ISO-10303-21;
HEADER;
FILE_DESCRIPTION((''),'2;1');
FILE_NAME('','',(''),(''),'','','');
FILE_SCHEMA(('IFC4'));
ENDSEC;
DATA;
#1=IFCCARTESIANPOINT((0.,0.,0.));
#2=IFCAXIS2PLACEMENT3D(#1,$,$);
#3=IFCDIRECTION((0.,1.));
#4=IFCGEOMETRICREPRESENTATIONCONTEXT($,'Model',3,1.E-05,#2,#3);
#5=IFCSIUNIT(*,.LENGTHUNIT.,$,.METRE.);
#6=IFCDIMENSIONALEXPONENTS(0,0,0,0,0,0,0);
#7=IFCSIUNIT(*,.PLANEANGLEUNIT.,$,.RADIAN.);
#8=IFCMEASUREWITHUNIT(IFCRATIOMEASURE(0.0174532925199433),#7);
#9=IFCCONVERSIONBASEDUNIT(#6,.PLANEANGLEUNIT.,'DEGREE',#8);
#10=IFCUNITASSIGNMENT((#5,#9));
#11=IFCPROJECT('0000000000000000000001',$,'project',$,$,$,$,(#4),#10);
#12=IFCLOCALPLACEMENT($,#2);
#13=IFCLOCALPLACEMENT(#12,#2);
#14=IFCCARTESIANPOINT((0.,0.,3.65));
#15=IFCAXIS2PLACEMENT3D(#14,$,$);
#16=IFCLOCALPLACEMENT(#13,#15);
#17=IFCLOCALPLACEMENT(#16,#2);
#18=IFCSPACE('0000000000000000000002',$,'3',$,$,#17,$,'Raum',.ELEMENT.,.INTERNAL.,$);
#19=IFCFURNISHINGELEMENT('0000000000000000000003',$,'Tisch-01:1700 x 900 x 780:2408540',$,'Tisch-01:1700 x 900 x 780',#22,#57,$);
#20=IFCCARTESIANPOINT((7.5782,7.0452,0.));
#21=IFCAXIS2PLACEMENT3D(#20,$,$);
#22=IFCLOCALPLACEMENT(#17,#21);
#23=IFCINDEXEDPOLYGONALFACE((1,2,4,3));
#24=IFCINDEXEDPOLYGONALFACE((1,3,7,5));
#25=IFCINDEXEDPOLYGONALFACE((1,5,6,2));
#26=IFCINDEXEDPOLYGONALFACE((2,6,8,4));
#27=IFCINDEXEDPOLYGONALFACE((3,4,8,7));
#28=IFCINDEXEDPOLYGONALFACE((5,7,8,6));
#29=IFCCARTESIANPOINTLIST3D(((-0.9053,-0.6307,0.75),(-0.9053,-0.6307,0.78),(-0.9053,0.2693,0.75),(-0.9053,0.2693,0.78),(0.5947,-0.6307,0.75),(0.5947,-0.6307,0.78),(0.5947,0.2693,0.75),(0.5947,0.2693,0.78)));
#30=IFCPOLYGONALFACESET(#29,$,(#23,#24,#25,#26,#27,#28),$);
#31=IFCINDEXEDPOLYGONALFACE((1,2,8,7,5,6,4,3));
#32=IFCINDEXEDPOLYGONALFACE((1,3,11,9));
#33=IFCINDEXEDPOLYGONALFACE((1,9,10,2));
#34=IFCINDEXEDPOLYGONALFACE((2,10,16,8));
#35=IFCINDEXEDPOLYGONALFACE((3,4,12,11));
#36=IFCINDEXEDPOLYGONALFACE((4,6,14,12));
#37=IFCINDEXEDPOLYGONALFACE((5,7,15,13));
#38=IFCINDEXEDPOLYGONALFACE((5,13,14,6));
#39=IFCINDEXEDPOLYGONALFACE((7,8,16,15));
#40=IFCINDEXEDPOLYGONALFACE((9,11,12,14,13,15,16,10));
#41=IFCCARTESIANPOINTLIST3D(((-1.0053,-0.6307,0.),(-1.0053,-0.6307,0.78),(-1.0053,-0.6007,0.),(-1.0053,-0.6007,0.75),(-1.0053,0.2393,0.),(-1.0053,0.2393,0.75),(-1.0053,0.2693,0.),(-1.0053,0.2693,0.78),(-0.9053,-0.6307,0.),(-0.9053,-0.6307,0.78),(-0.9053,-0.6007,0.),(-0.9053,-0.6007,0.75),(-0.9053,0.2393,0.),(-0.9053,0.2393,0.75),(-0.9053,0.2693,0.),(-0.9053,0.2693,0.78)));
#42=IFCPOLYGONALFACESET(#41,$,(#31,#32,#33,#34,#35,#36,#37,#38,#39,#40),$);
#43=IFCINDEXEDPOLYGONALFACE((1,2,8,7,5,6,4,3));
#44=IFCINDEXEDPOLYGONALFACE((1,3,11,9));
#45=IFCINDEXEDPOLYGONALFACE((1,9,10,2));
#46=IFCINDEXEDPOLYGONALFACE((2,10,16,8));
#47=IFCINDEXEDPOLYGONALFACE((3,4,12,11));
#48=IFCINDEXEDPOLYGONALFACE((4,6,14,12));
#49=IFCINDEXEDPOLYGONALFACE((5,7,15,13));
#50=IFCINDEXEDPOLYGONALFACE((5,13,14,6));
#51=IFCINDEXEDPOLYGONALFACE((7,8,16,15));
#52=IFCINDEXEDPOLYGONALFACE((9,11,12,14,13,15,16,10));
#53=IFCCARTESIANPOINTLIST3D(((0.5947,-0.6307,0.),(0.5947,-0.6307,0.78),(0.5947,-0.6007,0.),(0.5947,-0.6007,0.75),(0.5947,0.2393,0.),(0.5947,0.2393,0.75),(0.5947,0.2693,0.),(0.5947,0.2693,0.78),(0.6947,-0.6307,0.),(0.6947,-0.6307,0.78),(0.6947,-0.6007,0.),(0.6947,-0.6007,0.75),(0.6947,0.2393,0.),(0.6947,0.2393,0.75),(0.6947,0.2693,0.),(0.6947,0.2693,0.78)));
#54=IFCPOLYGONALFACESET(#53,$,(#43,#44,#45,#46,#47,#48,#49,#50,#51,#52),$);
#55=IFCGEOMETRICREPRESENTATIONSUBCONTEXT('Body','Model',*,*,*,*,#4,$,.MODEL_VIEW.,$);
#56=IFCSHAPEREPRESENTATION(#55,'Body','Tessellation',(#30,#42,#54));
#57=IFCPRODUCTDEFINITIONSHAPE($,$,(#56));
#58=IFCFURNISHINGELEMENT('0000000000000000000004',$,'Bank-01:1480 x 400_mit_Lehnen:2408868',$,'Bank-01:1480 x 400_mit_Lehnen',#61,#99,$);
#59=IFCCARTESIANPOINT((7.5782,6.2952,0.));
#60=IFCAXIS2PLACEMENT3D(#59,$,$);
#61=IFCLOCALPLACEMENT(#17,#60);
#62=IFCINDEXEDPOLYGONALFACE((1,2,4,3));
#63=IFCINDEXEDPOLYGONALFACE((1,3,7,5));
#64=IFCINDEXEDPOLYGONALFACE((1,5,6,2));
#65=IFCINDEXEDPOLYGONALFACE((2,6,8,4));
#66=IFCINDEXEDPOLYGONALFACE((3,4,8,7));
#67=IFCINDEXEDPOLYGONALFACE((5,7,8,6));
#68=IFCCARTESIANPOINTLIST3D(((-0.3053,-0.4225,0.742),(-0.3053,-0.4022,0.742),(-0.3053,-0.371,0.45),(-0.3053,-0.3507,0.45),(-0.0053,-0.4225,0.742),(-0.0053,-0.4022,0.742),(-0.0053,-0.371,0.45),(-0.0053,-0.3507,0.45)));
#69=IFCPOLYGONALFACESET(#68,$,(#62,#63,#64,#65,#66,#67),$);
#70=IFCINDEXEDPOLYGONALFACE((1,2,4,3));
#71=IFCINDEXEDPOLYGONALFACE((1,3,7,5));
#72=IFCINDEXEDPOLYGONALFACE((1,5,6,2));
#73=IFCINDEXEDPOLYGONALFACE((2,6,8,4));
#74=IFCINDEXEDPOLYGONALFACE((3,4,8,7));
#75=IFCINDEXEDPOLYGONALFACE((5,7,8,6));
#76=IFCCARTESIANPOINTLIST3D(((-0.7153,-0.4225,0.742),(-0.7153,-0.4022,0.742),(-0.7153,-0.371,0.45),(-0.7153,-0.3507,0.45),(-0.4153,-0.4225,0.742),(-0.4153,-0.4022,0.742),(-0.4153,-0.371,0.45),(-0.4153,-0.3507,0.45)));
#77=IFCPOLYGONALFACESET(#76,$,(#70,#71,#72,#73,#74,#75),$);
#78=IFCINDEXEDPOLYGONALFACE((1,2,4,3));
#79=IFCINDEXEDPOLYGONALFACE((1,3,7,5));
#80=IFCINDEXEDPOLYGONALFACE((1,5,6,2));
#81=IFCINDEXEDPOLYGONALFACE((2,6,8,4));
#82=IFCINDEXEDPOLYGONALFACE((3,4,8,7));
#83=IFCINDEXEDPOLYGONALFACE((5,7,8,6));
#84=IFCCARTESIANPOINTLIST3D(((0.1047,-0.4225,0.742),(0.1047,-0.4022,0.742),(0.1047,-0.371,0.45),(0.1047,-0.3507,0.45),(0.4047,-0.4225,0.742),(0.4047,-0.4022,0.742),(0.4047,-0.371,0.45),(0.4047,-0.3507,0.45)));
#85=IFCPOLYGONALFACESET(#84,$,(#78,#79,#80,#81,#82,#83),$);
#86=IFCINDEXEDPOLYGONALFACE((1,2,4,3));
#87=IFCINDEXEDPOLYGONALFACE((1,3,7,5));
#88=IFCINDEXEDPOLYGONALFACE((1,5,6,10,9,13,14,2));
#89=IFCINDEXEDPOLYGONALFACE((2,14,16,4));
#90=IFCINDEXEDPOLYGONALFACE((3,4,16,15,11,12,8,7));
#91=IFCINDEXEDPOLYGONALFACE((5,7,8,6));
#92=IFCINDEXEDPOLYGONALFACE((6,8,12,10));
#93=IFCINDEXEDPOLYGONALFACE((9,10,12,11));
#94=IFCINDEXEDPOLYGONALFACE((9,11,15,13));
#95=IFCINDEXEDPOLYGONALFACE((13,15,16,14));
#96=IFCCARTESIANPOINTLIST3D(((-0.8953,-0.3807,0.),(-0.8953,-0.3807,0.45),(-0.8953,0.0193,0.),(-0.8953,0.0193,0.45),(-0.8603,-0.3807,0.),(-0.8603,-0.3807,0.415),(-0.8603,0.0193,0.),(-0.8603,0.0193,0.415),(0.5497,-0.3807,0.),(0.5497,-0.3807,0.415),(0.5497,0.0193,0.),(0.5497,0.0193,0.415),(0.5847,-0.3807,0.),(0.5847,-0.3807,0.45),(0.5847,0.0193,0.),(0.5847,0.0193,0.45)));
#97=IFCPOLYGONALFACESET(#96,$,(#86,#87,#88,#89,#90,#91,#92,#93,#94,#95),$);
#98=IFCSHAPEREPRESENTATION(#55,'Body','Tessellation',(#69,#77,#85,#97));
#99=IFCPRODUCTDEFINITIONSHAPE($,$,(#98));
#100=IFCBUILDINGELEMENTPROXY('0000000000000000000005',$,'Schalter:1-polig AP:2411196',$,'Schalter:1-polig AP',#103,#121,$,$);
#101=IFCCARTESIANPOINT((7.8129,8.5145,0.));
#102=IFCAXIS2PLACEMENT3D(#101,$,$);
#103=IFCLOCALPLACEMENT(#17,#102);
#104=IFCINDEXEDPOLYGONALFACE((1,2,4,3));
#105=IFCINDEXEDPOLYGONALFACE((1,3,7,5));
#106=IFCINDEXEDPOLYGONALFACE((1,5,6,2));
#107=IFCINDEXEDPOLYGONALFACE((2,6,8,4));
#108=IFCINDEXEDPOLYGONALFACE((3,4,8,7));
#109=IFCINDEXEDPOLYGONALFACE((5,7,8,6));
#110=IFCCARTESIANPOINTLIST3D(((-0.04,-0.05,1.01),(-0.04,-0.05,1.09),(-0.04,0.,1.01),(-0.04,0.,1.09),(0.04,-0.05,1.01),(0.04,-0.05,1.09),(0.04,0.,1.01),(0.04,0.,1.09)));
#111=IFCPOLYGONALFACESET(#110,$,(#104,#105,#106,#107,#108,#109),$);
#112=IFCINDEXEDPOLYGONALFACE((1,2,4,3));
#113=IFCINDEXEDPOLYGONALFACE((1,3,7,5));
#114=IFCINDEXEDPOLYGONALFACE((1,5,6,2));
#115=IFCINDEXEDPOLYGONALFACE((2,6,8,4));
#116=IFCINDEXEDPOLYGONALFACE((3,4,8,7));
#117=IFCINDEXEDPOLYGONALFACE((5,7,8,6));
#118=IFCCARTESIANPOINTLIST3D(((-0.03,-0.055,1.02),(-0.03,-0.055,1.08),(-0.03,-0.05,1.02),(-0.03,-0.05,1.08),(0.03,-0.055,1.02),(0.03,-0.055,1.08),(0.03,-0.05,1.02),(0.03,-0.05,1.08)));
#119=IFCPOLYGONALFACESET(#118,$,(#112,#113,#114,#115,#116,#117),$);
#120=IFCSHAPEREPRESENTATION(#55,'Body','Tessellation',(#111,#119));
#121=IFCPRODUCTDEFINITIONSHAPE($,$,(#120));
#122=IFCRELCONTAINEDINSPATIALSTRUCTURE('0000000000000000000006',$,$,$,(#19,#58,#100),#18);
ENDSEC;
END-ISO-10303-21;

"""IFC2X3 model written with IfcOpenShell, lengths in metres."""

from ifc_helpers import new_model, entity, si_unit, converted_unit, direction, frame, frame_2d, origin, origin_2d_with_axis, place, context, subcontext, project, spatial, polyline, rectangle, outline, extrude, source, transform, mapped, element, save


model = new_model("IFC2X3")

# Units and contexts
model_context = context("Model", 3, precision=1e-05, world=origin(), true_north=direction((0.0, 1.0)))
body_context = subcontext(model_context, "Body", "Model", "MODEL_VIEW")
ifc_project = project(units=[si_unit("LENGTHUNIT", "METRE"), converted_unit("PLANEANGLEUNIT", "DEGREE", entity("IfcRatioMeasure", 0.0174532925199433), si_unit("PLANEANGLEUNIT", "RADIAN"), dimensions=[0, 0, 0, 0, 0, 0, 0])], contexts=[model_context])

# Shared definitions
placement_1 = place(None, origin())
placement_2 = place(placement_1, origin())

# Shared definitions
placement_3 = place(placement_2, frame((0.0, 0.0, 3.65)))

# Shared definitions
space_placement = place(placement_3, origin())
space = spatial("IfcSpace", at=space_placement, Name="3", LongName="Raum", CompositionType="ELEMENT", InteriorOrExteriorSpace="INTERNAL")

# Furnishing elements
shared_shape_1 = source(origin(), body_context, "Body", "SweptSolid", [
    extrude(rectangle(XDim=1.5, YDim=0.9, at=origin_2d_with_axis()), frame((-0.1553, -0.1807, 0.75), z_axis=(0.0, 0.0, 1.0), x_axis=(-1.0, 0.0, 0.0)), (0.0, 0.0, 1.0), 0.03),
    extrude(outline(polyline([(-0.3975, -0.45), (0.3825, -0.45), (0.3825, -0.42), (-0.3675, -0.42), (-0.3675, 0.42), (0.3825, 0.42), (0.3825, 0.45), (-0.3975, 0.45), (-0.3975, -0.45)])), frame((-1.0053, -0.1807, 0.3825), z_axis=(1.0, 0.0, 0.0), x_axis=(0.0, 0.0, -1.0)), (0.0, 0.0, 1.0), 0.1),
    extrude(outline(polyline([(-0.3975, -0.45), (0.3825, -0.45), (0.3825, -0.42), (-0.3675, -0.42), (-0.3675, 0.42), (0.3825, 0.42), (0.3825, 0.45), (-0.3975, 0.45), (-0.3975, -0.45)])), frame((0.5947, -0.1807, 0.3825), z_axis=(1.0, 0.0, 0.0), x_axis=(0.0, 0.0, -1.0)), (0.0, 0.0, 1.0), 0.1),
])
furnishing_1_placement = place(space_placement, frame((7.5782, 7.0452, 0.0)))
element("IfcFurnishingElement", 1, at=furnishing_1_placement, inside=space, Name="Tisch-01:1700 x 900 x 780:2408540", ObjectType="Tisch-01:1700 x 900 x 780", context=body_context, shape_type="MappedRepresentation", body=[
    mapped(shared_shape_1, transform((0.0, 0.0, 0.0), scale=1.0)),
])
shared_shape_2 = source(origin(), body_context, "Body", "SweptSolid", [
    extrude(outline(polyline([(0.0156, -0.146), (0.0359, -0.146), (-0.0156, 0.146), (-0.0359, 0.146), (0.0156, -0.146)])), frame((-0.3053, -0.3866, 0.596), z_axis=(1.0, 0.0, 0.0), x_axis=(0.0, -1.0, 0.0)), (0.0, 0.0, 1.0), 0.3),
    extrude(outline(polyline([(0.0156, -0.146), (0.0359, -0.146), (-0.0156, 0.146), (-0.0359, 0.146), (0.0156, -0.146)])), frame((-0.7153, -0.3866, 0.596), z_axis=(1.0, 0.0, 0.0), x_axis=(0.0, -1.0, 0.0)), (0.0, 0.0, 1.0), 0.3),
    extrude(outline(polyline([(0.0156, -0.146), (0.0359, -0.146), (-0.0156, 0.146), (-0.0359, 0.146), (0.0156, -0.146)])), frame((0.1047, -0.3866, 0.596), z_axis=(1.0, 0.0, 0.0), x_axis=(0.0, -1.0, 0.0)), (0.0, 0.0, 1.0), 0.3),
    extrude(outline(polyline([(-0.74, -0.2337), (0.74, -0.2337), (0.74, 0.2163), (0.705, 0.2163), (0.705, -0.1988), (-0.705, -0.1988), (-0.705, 0.2163), (-0.74, 0.2163), (-0.74, -0.2337)])), frame((-0.1553, -0.3807, 0.2163), z_axis=(0.0, 1.0, 0.0), x_axis=(1.0, 0.0, 0.0)), (0.0, 0.0, 1.0), 0.4),
])
furnishing_2_placement = place(space_placement, frame((7.5782, 6.2952, 0.0)))
element("IfcFurnishingElement", 2, at=furnishing_2_placement, inside=space, Name="Bank-01:1480 x 400_mit_Lehnen:2408868", ObjectType="Bank-01:1480 x 400_mit_Lehnen", context=body_context, shape_type="MappedRepresentation", body=[
    mapped(shared_shape_2, transform((0.0, 0.0, 0.0), scale=1.0)),
])

# Building element proxy
shared_shape_3 = source(origin(), body_context, "Body", "SweptSolid", [
    extrude(rectangle(XDim=0.05, YDim=0.08, at=origin_2d_with_axis()), frame((0.0, -0.025, 1.01), z_axis=(0.0, 0.0, 1.0), x_axis=(0.0, 1.0, 0.0)), (0.0, 0.0, 1.0), 0.08),
    extrude(rectangle(XDim=0.005, YDim=0.06, at=frame_2d((0.0, 0.0), x_axis=(1.0, 0.0))), frame((0.0, -0.0525, 1.02), z_axis=(0.0, 0.0, 1.0), x_axis=(0.0, 1.0, 0.0)), (0.0, 0.0, 1.0), 0.06),
])
proxy_placement = place(space_placement, frame((7.8129, 8.5145, 0.0)))
element("IfcBuildingElementProxy", 3, at=proxy_placement, inside=space, Name="Schalter:1-polig AP:2411196", ObjectType="Schalter:1-polig AP", context=body_context, shape_type="MappedRepresentation", body=[
    mapped(shared_shape_3, transform((0.0, 0.0, 0.0), scale=1.0)),
])

save(model, "model.ifc")
